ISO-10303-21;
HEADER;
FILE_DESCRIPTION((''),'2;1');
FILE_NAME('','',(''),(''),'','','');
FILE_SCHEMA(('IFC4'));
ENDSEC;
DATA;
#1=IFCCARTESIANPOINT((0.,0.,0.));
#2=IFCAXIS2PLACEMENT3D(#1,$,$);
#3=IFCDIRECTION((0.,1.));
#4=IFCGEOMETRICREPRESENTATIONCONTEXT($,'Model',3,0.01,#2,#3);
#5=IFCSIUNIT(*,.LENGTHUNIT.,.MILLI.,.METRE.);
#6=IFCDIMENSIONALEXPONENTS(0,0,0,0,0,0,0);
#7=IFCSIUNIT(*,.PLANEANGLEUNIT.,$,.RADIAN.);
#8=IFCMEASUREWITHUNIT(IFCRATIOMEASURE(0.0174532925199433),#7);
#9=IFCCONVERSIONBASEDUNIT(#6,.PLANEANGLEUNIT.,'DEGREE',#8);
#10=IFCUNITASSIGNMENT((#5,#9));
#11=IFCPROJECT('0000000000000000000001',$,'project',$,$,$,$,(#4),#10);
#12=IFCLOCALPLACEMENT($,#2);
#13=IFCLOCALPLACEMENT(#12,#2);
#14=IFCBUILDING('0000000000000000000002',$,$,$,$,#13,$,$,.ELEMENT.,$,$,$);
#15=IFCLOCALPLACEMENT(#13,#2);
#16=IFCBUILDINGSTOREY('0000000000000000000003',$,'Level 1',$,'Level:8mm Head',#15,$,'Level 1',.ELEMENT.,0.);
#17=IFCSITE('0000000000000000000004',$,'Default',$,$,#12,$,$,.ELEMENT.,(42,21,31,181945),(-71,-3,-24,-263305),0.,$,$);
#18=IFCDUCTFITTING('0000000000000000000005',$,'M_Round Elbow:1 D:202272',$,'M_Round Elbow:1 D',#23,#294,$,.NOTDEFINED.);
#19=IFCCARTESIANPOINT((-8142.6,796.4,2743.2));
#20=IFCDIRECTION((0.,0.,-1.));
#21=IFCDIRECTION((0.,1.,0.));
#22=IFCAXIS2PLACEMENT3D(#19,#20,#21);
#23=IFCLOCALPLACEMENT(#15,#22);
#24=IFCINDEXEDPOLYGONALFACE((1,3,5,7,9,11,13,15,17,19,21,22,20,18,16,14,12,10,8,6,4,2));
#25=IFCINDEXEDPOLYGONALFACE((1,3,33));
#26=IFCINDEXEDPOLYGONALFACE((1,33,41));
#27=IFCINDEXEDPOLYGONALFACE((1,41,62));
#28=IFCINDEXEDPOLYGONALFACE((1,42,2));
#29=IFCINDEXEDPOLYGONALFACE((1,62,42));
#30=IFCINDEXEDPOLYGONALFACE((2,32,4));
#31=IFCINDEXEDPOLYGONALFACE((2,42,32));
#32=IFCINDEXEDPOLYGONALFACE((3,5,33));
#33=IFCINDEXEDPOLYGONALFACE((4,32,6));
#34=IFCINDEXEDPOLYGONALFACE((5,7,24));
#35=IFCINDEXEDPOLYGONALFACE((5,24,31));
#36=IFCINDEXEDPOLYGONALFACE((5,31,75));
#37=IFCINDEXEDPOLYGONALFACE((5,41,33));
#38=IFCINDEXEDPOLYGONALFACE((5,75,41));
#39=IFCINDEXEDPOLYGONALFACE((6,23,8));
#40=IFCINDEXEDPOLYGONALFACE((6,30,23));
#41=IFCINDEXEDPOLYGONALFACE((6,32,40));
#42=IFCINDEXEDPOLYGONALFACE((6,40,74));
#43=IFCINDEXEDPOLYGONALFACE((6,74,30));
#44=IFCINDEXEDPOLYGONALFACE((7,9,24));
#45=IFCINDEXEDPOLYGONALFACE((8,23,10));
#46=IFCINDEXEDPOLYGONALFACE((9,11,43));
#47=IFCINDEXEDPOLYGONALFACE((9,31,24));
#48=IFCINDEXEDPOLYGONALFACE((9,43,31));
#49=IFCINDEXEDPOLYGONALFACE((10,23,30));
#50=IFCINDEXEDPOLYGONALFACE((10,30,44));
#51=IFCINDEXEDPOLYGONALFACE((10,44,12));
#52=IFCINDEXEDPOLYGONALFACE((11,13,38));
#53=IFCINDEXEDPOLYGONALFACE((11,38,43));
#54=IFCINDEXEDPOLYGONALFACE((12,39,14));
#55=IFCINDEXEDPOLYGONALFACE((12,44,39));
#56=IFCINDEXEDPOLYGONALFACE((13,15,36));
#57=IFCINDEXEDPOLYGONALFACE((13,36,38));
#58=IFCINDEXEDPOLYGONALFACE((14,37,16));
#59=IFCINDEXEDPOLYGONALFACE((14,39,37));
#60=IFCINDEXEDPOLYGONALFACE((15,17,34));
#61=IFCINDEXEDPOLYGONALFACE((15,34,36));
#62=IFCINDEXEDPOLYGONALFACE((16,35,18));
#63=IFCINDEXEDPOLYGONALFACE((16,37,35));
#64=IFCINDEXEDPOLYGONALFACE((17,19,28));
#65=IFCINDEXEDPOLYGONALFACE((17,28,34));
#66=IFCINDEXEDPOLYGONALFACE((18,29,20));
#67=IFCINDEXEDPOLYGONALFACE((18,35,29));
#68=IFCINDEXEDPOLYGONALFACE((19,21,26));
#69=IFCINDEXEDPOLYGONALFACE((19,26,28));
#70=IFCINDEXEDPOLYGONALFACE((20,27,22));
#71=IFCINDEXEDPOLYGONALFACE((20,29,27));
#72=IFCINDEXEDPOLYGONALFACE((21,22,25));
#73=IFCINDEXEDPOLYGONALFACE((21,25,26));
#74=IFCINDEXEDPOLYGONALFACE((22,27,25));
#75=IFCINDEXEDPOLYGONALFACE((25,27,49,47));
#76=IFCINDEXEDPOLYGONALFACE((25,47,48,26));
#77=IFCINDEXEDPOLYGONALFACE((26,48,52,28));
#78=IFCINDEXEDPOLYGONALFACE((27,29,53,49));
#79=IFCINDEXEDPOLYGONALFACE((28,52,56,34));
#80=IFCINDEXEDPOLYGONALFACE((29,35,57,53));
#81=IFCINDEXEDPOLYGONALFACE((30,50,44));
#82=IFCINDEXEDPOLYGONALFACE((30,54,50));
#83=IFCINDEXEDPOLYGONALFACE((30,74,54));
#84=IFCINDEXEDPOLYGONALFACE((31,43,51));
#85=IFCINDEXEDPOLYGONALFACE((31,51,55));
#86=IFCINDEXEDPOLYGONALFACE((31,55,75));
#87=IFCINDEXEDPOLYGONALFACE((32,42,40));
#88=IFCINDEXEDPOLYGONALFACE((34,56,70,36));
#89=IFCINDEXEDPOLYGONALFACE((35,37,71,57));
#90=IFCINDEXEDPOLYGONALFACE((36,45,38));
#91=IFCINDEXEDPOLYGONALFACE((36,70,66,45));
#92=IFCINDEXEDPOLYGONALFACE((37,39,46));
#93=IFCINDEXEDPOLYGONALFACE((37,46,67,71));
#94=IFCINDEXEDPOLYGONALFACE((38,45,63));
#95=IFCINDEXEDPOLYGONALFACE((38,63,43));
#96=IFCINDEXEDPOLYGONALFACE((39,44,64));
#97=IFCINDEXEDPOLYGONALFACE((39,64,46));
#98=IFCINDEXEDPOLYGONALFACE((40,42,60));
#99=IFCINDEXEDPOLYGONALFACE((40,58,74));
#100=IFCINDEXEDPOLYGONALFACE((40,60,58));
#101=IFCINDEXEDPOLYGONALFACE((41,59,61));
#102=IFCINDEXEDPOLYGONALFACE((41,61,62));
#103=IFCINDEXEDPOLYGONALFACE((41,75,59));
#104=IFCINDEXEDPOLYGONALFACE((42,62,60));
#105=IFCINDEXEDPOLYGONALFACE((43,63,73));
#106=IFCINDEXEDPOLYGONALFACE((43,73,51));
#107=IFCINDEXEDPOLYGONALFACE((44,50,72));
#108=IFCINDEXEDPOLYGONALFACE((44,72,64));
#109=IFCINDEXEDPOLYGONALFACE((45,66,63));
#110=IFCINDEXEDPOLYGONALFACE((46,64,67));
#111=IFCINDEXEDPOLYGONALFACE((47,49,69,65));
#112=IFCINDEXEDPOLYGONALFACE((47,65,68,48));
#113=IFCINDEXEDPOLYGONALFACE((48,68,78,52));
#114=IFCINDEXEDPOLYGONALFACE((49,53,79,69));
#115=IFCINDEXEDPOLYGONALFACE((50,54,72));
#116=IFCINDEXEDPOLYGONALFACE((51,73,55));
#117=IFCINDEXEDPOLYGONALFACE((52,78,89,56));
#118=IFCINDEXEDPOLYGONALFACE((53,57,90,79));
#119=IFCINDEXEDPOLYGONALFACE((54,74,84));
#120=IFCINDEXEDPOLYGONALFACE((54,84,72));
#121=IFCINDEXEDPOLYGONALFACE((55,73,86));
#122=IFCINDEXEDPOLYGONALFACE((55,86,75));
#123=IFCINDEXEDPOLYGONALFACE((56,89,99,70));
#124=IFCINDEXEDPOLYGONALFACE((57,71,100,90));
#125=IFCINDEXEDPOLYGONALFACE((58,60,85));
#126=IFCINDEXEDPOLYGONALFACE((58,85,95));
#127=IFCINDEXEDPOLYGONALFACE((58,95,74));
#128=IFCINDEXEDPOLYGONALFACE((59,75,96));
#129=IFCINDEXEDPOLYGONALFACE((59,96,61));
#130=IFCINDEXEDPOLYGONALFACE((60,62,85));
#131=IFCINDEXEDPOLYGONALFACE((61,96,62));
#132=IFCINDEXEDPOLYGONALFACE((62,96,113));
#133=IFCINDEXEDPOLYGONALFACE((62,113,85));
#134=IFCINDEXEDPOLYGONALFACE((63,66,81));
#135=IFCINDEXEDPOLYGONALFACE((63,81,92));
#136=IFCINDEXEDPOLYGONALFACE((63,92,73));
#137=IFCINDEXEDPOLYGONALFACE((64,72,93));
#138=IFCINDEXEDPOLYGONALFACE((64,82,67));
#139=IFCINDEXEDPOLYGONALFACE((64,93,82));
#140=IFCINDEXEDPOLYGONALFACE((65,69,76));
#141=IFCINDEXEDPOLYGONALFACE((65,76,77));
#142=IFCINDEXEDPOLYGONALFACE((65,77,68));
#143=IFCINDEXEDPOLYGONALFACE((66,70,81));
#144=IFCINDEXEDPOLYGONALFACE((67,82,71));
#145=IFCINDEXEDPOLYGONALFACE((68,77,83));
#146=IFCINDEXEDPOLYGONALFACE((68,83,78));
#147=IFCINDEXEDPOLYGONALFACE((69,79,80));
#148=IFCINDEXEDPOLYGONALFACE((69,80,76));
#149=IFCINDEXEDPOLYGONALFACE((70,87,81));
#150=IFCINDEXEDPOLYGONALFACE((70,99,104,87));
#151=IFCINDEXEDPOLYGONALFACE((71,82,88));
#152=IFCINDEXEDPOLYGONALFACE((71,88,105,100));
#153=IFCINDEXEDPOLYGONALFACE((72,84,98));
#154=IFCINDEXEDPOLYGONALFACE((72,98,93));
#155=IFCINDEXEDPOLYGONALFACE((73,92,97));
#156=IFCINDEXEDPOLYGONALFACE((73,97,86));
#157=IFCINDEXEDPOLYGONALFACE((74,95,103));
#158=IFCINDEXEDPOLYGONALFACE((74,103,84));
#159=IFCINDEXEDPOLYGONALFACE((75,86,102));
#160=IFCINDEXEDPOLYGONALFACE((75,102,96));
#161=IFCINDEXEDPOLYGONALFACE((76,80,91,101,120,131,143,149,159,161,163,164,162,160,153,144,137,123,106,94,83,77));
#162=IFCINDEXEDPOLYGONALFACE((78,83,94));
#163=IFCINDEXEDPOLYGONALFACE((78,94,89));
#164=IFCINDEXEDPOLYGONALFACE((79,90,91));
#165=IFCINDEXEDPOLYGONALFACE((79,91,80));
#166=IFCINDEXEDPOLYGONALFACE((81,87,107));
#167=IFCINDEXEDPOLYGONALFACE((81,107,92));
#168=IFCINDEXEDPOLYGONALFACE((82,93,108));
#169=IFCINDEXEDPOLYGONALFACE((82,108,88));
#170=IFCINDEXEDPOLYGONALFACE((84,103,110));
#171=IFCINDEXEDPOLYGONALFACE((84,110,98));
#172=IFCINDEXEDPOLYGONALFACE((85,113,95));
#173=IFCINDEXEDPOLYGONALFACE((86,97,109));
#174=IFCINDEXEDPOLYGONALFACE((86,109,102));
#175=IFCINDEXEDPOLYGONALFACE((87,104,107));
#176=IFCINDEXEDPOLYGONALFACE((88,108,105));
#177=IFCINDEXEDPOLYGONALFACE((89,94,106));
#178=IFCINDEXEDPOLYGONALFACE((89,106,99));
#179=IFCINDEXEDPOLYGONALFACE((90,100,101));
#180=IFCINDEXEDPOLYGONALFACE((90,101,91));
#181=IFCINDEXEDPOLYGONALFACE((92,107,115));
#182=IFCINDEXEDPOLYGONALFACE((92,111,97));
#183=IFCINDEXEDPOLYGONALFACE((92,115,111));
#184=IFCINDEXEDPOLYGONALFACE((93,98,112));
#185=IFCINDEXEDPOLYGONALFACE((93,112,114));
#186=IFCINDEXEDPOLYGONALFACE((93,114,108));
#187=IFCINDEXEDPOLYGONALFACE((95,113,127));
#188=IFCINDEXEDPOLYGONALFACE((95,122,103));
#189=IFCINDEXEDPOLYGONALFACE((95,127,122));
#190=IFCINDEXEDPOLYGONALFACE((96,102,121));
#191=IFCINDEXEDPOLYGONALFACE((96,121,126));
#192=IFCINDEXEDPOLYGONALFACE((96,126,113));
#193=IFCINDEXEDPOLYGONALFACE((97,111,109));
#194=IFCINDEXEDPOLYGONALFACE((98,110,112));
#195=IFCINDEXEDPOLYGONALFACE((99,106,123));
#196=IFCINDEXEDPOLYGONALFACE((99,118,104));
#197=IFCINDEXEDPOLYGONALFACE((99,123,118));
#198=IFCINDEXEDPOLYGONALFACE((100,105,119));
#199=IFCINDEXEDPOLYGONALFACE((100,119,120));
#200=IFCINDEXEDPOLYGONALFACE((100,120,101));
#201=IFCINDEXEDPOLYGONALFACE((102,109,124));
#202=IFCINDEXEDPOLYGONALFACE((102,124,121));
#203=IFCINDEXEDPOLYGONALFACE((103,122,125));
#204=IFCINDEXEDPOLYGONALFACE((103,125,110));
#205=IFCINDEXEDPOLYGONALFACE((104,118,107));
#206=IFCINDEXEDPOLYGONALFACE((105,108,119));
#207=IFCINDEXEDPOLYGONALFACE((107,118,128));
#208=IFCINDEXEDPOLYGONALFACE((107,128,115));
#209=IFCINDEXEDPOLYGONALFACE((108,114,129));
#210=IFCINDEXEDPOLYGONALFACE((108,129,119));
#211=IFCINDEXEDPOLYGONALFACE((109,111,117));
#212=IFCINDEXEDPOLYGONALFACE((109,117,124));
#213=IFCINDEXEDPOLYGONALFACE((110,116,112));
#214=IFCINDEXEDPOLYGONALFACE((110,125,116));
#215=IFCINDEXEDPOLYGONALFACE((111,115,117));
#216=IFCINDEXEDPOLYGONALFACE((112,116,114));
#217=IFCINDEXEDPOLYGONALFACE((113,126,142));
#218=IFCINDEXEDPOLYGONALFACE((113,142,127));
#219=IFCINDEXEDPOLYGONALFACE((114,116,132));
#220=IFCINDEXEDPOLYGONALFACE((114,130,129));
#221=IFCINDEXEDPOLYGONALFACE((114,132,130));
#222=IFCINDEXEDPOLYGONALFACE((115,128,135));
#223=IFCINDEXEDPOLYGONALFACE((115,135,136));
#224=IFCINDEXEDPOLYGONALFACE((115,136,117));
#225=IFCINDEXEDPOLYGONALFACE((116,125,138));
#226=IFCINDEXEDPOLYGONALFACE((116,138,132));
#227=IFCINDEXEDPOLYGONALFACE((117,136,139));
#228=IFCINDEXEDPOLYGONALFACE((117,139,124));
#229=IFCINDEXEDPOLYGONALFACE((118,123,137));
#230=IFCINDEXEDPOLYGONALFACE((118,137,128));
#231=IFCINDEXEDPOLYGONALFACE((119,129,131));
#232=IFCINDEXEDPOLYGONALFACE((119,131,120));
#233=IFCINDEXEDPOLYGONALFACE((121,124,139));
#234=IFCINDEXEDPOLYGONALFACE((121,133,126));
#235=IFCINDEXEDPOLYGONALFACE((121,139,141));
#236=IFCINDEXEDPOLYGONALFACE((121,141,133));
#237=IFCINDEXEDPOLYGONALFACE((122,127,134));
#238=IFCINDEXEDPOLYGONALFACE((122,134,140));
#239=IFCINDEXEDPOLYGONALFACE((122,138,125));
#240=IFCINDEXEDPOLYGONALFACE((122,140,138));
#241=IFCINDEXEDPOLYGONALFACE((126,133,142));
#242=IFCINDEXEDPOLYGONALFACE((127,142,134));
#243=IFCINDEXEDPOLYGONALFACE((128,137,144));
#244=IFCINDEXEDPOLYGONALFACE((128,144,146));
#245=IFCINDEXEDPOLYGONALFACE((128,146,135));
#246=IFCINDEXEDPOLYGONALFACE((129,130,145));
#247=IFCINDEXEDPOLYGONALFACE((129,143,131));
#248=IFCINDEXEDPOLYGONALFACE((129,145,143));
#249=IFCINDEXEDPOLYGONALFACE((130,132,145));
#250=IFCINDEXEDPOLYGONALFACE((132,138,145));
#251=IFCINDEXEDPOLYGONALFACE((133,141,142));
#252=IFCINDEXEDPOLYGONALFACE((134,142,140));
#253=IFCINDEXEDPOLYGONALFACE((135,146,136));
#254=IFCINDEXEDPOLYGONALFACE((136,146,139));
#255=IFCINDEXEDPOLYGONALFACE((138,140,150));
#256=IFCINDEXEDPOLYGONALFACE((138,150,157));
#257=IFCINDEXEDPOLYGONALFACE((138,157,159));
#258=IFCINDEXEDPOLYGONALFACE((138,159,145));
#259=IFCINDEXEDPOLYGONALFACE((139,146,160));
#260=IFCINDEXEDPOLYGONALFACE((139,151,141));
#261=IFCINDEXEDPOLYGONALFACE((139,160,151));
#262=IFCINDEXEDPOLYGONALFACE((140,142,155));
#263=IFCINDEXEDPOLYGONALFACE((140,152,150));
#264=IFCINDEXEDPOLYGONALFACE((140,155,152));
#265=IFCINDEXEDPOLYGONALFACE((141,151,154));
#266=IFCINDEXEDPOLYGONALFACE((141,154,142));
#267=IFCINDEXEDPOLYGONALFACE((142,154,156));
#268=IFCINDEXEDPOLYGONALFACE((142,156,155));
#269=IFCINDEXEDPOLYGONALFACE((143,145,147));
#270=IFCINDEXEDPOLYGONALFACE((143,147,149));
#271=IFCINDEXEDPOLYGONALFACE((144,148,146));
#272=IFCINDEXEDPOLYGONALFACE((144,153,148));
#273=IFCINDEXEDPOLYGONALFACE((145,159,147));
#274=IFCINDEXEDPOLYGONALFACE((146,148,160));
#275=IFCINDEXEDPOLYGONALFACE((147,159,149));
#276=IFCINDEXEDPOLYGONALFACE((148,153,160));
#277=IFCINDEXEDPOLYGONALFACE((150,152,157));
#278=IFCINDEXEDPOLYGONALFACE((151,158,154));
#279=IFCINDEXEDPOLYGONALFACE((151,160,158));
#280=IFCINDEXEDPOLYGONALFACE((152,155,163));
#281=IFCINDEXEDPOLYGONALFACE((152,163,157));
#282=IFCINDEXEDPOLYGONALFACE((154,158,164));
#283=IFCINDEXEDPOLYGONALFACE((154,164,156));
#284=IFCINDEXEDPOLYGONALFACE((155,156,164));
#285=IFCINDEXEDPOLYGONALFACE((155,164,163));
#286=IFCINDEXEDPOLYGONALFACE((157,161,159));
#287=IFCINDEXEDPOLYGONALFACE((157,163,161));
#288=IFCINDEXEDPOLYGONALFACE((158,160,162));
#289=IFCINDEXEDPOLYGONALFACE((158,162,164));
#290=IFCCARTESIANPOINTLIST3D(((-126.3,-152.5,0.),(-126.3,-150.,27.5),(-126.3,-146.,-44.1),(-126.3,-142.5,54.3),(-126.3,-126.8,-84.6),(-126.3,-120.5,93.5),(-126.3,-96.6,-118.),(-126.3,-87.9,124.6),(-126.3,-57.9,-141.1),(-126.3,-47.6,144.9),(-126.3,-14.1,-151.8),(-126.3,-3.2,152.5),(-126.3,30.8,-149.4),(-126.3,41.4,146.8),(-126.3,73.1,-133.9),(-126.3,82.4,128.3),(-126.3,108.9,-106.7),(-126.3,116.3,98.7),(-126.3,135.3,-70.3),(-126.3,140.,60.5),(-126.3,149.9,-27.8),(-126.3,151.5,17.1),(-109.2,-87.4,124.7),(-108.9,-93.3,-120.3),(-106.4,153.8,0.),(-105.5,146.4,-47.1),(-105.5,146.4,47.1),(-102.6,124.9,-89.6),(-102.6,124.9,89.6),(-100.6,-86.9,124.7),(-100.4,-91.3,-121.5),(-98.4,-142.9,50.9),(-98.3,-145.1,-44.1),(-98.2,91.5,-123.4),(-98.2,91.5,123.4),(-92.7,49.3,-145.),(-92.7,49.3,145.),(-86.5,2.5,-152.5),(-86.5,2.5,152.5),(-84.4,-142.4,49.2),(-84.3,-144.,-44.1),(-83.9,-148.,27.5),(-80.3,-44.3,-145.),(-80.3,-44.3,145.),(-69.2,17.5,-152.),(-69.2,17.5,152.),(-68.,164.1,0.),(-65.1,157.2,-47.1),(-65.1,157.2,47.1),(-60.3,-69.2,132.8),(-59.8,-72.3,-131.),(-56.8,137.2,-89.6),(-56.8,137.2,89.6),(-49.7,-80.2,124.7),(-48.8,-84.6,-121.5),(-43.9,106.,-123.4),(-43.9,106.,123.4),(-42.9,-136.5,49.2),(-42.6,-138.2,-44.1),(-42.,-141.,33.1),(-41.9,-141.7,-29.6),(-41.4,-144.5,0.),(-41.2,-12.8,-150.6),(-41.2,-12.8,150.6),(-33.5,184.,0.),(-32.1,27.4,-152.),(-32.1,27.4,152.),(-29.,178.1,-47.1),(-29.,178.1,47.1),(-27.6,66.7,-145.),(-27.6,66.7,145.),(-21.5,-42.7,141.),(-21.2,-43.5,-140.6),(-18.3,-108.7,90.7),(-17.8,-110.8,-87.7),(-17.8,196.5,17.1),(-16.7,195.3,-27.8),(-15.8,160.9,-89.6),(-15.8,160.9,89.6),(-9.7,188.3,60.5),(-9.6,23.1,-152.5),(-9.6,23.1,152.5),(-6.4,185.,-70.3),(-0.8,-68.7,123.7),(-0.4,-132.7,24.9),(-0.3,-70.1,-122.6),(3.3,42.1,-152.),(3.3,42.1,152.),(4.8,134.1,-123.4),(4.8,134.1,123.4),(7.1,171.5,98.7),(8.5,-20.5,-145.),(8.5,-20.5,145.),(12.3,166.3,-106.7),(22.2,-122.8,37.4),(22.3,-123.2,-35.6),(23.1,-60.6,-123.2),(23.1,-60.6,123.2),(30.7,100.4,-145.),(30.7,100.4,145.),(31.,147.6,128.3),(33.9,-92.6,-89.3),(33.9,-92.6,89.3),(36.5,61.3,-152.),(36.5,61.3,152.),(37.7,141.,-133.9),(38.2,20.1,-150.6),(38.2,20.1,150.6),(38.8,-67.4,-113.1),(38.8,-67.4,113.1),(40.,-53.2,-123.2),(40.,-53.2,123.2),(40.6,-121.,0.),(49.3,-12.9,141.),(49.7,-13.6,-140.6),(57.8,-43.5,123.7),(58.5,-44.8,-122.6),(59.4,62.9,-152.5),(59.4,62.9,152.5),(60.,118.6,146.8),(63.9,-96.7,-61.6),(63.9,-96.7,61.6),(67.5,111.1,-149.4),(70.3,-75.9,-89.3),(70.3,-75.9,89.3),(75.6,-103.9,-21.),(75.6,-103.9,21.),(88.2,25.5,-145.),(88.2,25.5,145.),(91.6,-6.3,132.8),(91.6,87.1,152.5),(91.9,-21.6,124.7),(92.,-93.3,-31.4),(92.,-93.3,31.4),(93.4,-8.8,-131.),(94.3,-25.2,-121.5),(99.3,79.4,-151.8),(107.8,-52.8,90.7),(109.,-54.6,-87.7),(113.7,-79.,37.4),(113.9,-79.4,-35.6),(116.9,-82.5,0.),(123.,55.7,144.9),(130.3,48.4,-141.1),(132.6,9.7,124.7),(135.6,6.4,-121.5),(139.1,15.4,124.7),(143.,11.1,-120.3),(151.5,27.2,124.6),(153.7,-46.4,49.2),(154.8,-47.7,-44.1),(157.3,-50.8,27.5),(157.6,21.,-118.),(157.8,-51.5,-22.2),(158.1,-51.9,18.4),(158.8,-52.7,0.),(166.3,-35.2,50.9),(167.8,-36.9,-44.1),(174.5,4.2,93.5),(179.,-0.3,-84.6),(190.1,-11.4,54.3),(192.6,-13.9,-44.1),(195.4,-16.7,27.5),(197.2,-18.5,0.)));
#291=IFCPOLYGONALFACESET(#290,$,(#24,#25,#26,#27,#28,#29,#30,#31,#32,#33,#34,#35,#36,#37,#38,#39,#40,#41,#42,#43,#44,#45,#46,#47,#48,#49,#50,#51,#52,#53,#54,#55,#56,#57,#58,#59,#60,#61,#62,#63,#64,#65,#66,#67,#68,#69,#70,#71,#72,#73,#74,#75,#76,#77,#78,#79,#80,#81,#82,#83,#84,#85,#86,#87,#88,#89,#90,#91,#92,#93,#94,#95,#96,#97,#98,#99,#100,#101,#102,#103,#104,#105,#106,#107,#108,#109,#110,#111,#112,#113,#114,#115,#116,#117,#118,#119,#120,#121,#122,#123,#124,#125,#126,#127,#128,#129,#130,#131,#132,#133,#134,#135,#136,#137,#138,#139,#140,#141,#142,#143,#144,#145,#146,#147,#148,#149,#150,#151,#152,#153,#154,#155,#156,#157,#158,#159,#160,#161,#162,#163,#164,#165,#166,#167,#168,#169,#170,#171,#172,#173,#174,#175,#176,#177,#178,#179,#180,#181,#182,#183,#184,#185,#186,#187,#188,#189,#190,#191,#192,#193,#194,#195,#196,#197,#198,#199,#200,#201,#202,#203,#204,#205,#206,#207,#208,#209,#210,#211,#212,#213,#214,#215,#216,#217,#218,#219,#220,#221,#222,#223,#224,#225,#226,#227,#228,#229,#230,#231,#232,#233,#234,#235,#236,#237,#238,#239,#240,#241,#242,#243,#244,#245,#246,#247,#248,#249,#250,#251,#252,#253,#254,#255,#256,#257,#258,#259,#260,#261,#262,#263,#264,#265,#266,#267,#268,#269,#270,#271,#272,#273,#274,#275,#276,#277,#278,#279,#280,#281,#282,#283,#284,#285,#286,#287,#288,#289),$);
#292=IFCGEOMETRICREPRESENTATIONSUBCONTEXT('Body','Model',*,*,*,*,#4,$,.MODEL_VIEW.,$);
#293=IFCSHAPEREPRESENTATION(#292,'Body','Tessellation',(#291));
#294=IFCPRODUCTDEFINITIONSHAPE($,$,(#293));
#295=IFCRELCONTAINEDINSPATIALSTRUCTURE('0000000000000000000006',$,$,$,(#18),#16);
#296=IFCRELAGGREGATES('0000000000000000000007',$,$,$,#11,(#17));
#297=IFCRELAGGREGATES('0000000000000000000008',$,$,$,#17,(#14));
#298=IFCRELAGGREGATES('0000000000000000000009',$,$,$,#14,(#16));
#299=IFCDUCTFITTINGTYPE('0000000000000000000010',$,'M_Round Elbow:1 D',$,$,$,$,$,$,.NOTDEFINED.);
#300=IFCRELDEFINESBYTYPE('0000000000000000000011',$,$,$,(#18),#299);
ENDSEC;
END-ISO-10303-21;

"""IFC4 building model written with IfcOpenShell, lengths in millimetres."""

from ifc_helpers import new_model, entity, si_unit, converted_unit, direction, frame, origin, place, context, subcontext, project, spatial, source, transform, mapped, type_object, type_shapes, element, save


model = new_model("IFC4")

# Units and contexts
model_context = context("Model", 3, precision=0.01, world=origin(), true_north=direction((0.0, 1.0)))
body_context = subcontext(model_context, "Body", "Model", "MODEL_VIEW")
ifc_project = project(units=[si_unit("LENGTHUNIT", "METRE", prefix="MILLI"), converted_unit("PLANEANGLEUNIT", "DEGREE", entity("IfcRatioMeasure", 0.0174532925199433), si_unit("PLANEANGLEUNIT", "RADIAN"), dimensions=[0, 0, 0, 0, 0, 0, 0])], contexts=[model_context])

# Site, building, storey
site_placement = place(None, origin())
site = spatial("IfcSite", under=ifc_project, at=site_placement, Name="Default", CompositionType="ELEMENT", RefLatitude=(42, 21, 31, 181945), RefLongitude=(-71, -3, -24, -263305), RefElevation=0.0)
building_placement = place(site_placement, origin())
building = spatial("IfcBuilding", under=site, at=building_placement, CompositionType="ELEMENT")
storey_placement = place(building_placement, origin())
storey = spatial("IfcBuildingStorey", under=building, at=storey_placement, Name="Level 1", ObjectType="Level:8mm Head", LongName="Level 1", CompositionType="ELEMENT", Elevation=0.0)

# Duct fitting
duct_fitting_type = type_object("IfcDuctFittingType", Name="M_Round Elbow:1 D", PredefinedType="NOTDEFINED")
ifc_direction = entity("IfcDirection", [0.0, 0.0, 1.0])
trimmed_curve = entity("IfcTrimmedCurve", entity("IfcCircle", entity("IfcAxis2Placement2D", entity("IfcCartesianPoint", [-305.0, 0.0]), entity("IfcDirection", [0.0, 1.0])), 305.0), [entity("IfcParameterValue", 270.0)], [entity("IfcParameterValue", 315.0)], True, "PARAMETER")
shared_shape = source(origin(), body_context, "Body", "AdvancedSweptSolid", [
    entity("IfcSurfaceCurveSweptAreaSolid", entity("IfcCircleProfileDef", "AREA", None, entity("IfcAxis2Placement2D", entity("IfcCartesianPoint", [0.0, 0.0]), entity("IfcDirection", [1.0, 0.0])), 152.5), entity("IfcAxis2Placement3D", entity("IfcCartesianPoint", [-126.3, 0.0, 0.0]), ifc_direction, entity("IfcDirection", [0.0, -1.0, 0.0])), trimmed_curve, 0.0, 45.0, entity("IfcSurfaceOfLinearExtrusion", entity("IfcArbitraryOpenProfileDef", "CURVE", None, trimmed_curve), entity("IfcAxis2Placement3D", entity("IfcCartesianPoint", [0.0, 0.0, -304.8])), ifc_direction, 1.0)),
])
type_shapes(duct_fitting_type, [shared_shape])
duct_fitting_placement = place(storey_placement, frame((-8142.6, 796.4, 2743.2), z_axis=(0.0, 0.0, -1.0), x_axis=(0.0, 1.0, 0.0)))
element("IfcDuctFitting", 1, at=duct_fitting_placement, inside=storey, type_object=duct_fitting_type, Name="M_Round Elbow:1 D:202272", ObjectType="M_Round Elbow:1 D", PredefinedType="NOTDEFINED", context=body_context, shape_type="MappedRepresentation", body=[
    mapped(shared_shape, transform((0.0, 0.0, 0.0), scale=1.0)),
])

save(model, "model.ifc")
